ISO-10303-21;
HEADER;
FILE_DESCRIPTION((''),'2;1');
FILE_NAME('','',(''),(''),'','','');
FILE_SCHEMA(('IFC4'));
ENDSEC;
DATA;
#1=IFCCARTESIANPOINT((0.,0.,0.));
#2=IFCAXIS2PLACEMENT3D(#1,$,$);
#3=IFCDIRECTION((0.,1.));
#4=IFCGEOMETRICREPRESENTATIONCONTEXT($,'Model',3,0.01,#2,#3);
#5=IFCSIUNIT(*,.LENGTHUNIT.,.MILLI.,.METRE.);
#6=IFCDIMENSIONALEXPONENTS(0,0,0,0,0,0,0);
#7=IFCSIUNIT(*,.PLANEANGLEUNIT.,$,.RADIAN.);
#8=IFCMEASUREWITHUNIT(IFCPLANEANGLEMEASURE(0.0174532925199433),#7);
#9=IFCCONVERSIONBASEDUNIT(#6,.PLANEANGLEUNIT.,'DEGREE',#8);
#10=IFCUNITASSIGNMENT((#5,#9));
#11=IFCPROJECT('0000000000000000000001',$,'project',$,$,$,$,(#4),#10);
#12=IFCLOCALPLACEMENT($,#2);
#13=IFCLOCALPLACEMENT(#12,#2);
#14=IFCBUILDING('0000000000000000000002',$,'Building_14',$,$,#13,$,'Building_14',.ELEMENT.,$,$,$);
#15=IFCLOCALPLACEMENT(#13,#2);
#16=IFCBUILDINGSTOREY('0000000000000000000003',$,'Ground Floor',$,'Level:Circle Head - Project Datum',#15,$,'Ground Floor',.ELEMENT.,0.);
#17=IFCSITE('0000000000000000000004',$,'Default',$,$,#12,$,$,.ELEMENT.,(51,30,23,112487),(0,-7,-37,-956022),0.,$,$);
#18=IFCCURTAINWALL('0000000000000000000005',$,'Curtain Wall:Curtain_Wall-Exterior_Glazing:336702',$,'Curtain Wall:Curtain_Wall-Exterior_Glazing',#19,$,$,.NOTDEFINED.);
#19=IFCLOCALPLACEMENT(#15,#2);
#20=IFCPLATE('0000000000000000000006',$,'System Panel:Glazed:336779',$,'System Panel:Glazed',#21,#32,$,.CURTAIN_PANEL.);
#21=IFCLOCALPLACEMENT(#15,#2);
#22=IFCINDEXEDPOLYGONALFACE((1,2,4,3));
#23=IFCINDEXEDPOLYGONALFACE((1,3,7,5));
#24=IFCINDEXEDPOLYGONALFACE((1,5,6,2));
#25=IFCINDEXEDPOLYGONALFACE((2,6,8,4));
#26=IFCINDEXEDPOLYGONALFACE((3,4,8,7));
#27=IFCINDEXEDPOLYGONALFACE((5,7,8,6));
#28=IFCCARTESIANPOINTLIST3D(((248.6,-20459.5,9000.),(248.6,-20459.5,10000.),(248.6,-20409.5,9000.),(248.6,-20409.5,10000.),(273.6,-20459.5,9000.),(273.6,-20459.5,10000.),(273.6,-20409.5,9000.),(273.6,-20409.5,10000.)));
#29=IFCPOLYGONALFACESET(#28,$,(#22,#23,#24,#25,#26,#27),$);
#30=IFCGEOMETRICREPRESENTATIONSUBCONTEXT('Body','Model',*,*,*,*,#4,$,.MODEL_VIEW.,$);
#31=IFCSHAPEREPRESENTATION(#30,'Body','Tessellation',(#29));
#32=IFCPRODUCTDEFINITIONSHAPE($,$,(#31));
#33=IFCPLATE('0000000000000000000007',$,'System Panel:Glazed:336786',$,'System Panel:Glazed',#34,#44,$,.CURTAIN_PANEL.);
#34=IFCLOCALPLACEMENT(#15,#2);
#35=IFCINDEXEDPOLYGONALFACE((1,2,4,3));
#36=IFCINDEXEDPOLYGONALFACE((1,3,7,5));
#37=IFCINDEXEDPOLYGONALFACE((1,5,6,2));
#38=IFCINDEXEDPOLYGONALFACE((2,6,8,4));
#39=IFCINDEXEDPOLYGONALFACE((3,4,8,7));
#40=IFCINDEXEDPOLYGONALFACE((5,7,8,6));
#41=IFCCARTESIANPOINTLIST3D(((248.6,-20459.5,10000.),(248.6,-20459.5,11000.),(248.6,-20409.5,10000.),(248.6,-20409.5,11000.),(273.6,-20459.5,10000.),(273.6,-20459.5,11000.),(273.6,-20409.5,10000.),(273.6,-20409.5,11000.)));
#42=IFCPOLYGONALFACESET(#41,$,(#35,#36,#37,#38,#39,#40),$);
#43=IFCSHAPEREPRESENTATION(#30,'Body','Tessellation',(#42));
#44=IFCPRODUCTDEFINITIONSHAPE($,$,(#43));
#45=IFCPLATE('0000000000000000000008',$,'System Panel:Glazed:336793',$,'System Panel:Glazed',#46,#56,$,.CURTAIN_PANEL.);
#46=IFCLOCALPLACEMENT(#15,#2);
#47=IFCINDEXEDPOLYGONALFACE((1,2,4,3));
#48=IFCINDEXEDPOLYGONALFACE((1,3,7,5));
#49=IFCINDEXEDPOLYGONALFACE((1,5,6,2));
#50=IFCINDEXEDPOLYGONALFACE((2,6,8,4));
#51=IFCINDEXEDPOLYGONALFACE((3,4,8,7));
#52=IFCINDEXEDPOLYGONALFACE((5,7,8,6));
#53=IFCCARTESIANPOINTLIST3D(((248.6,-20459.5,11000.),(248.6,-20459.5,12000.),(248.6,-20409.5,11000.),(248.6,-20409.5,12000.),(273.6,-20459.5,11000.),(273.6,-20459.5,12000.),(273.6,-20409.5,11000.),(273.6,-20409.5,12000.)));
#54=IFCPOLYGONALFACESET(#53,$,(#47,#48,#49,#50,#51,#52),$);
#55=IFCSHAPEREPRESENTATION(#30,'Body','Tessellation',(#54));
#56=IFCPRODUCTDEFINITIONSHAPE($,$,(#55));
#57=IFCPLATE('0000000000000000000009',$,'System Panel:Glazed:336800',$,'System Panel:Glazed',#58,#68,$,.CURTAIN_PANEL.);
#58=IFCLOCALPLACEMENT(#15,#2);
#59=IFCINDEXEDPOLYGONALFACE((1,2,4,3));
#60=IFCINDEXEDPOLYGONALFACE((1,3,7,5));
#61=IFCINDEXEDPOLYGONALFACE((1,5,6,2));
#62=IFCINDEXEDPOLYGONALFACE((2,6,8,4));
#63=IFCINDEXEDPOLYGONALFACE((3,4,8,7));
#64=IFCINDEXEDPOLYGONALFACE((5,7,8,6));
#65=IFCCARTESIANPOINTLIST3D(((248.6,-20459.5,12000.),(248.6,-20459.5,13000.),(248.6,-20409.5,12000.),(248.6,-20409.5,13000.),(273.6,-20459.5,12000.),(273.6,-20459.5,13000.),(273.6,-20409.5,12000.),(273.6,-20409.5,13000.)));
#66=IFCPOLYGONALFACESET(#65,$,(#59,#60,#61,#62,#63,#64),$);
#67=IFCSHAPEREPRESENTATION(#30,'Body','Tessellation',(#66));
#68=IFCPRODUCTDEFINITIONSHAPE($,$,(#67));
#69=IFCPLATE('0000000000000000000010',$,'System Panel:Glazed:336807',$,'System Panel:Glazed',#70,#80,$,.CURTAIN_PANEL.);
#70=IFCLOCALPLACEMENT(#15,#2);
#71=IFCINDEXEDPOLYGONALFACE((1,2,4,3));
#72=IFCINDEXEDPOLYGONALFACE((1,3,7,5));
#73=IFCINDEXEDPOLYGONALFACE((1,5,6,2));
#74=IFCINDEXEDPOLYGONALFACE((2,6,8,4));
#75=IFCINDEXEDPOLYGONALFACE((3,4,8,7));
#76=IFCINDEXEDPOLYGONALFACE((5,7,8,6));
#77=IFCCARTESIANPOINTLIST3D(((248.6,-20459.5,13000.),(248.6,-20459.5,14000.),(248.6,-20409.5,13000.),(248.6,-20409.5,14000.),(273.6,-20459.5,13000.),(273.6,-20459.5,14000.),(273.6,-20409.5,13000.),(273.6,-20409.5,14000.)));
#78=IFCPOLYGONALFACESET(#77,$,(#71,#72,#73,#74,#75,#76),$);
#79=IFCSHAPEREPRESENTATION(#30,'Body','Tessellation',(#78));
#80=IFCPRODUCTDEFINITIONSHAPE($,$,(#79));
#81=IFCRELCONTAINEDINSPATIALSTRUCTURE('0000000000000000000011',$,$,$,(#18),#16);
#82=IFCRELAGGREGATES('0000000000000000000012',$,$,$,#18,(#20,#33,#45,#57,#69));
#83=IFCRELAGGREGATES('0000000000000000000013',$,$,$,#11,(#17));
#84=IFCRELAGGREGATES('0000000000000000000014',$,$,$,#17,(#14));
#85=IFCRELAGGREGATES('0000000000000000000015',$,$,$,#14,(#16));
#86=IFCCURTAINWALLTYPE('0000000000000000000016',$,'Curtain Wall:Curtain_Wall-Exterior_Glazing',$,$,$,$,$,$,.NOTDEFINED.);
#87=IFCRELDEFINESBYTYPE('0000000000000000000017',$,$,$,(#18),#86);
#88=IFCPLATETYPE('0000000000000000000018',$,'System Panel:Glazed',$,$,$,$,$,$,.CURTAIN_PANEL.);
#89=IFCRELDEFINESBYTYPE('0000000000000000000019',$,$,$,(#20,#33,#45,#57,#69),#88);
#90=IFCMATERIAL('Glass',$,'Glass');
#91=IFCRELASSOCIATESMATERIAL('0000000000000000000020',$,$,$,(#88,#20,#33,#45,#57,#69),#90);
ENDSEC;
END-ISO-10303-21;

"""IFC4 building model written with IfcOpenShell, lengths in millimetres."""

from ifc_helpers import new_model, entity, si_unit, converted_unit, direction, frame, origin, place, context, subcontext, project, spatial, indexed_curve, outline, extrude, source, transform, mapped, material, type_object, type_shapes, element, aggregate, save


model = new_model("IFC4")

# Units and contexts
model_context = context("Model", 3, precision=0.01, world=origin(), true_north=direction((0.0, 1.0)))
body_context = subcontext(model_context, "Body", "Model", "MODEL_VIEW")
ifc_project = project(units=[si_unit("LENGTHUNIT", "METRE", prefix="MILLI"), converted_unit("PLANEANGLEUNIT", "DEGREE", entity("IfcPlaneAngleMeasure", 0.0174532925199433), si_unit("PLANEANGLEUNIT", "RADIAN"), dimensions=[0, 0, 0, 0, 0, 0, 0])], contexts=[model_context])

# Site, building, storey
site_placement = place(None, origin())
site = spatial("IfcSite", under=ifc_project, at=site_placement, Name="Default", CompositionType="ELEMENT", RefLatitude=(51, 30, 23, 112487), RefLongitude=(0, -7, -37, -956022), RefElevation=0.0)
building_placement = place(site_placement, origin())
building = spatial("IfcBuilding", under=site, at=building_placement, Name="Building_14", LongName="Building_14", CompositionType="ELEMENT")
storey_placement = place(building_placement, origin())
storey = spatial("IfcBuildingStorey", under=building, at=storey_placement, Name="Ground Floor", ObjectType="Level:Circle Head - Project Datum", LongName="Ground Floor", CompositionType="ELEMENT", Elevation=0.0)

# Curtain wall
curtain_wall_type = type_object("IfcCurtainWallType", Name="Curtain Wall:Curtain_Wall-Exterior_Glazing", PredefinedType="NOTDEFINED")
curtain_wall_1_placement = place(storey_placement, origin())
curtain_wall_1 = element("IfcCurtainWall", 1, at=curtain_wall_1_placement, inside=storey, type_object=curtain_wall_type, Name="Curtain Wall:Curtain_Wall-Exterior_Glazing:336702", ObjectType="Curtain Wall:Curtain_Wall-Exterior_Glazing", PredefinedType="NOTDEFINED")
ifc_material = material(Name="Glass", Category="Glass")
plate_type_1 = type_object("IfcPlateType", Name="System Panel:Glazed", PredefinedType="CURTAIN_PANEL", material=ifc_material)
shared_shape_1 = source(origin(), body_context, "Body", "SweptSolid", [
    extrude(outline(indexed_curve([(-12.5, -25.0), (12.5, -25.0), (12.5, 25.0), (-12.5, 25.0), (-12.5, -25.0)], self_intersect=False)), frame((0.0, -37.0, 0.0), z_axis=(0.0, 0.0, 1.0), x_axis=(0.0, 1.0, 0.0)), (0.0, 0.0, 1.0), 1000.0),
])
type_shapes(plate_type_1, [shared_shape_1])

# Plates
plate_1_placement = place(curtain_wall_1_placement, frame((298.1, -20434.5, 9000.0), z_axis=(0.0, 0.0, 1.0), x_axis=(0.0, -1.0, 0.0)))
plate_1 = element("IfcPlate", 2, at=plate_1_placement, type_object=plate_type_1, material=ifc_material, Name="System Panel:Glazed:336779", ObjectType="System Panel:Glazed", PredefinedType="CURTAIN_PANEL", context=body_context, shape_type="MappedRepresentation", body=[
    mapped(shared_shape_1, transform((0.0, 0.0, 0.0), scale=1.0)),
])
plate_2_placement = place(curtain_wall_1_placement, frame((298.1, -20434.5, 10000.0), z_axis=(0.0, 0.0, 1.0), x_axis=(0.0, -1.0, 0.0)))
plate_2 = element("IfcPlate", 3, at=plate_2_placement, type_object=plate_type_1, material=ifc_material, Name="System Panel:Glazed:336786", ObjectType="System Panel:Glazed", PredefinedType="CURTAIN_PANEL", context=body_context, shape_type="MappedRepresentation", body=[
    mapped(shared_shape_1, transform((0.0, 0.0, 0.0), scale=1.0)),
])
plate_3_placement = place(curtain_wall_1_placement, frame((298.1, -20434.5, 11000.0), z_axis=(0.0, 0.0, 1.0), x_axis=(0.0, -1.0, 0.0)))
plate_3 = element("IfcPlate", 4, at=plate_3_placement, type_object=plate_type_1, material=ifc_material, Name="System Panel:Glazed:336793", ObjectType="System Panel:Glazed", PredefinedType="CURTAIN_PANEL", context=body_context, shape_type="MappedRepresentation", body=[
    mapped(shared_shape_1, transform((0.0, 0.0, 0.0), scale=1.0)),
])
plate_4_placement = place(curtain_wall_1_placement, frame((298.1, -20434.5, 12000.0), z_axis=(0.0, 0.0, 1.0), x_axis=(0.0, -1.0, 0.0)))
plate_4 = element("IfcPlate", 5, at=plate_4_placement, type_object=plate_type_1, material=ifc_material, Name="System Panel:Glazed:336800", ObjectType="System Panel:Glazed", PredefinedType="CURTAIN_PANEL", context=body_context, shape_type="MappedRepresentation", body=[
    mapped(shared_shape_1, transform((0.0, 0.0, 0.0), scale=1.0)),
])
plate_5_placement = place(curtain_wall_1_placement, frame((298.1, -20434.5, 13000.0), z_axis=(0.0, 0.0, 1.0), x_axis=(0.0, -1.0, 0.0)))
plate_5 = element("IfcPlate", 6, at=plate_5_placement, type_object=plate_type_1, material=ifc_material, Name="System Panel:Glazed:336807", ObjectType="System Panel:Glazed", PredefinedType="CURTAIN_PANEL", context=body_context, shape_type="MappedRepresentation", body=[
    mapped(shared_shape_1, transform((0.0, 0.0, 0.0), scale=1.0)),
])
aggregate(curtain_wall_1, [plate_1, plate_2, plate_3, plate_4, plate_5])

save(model, "model.ifc")
